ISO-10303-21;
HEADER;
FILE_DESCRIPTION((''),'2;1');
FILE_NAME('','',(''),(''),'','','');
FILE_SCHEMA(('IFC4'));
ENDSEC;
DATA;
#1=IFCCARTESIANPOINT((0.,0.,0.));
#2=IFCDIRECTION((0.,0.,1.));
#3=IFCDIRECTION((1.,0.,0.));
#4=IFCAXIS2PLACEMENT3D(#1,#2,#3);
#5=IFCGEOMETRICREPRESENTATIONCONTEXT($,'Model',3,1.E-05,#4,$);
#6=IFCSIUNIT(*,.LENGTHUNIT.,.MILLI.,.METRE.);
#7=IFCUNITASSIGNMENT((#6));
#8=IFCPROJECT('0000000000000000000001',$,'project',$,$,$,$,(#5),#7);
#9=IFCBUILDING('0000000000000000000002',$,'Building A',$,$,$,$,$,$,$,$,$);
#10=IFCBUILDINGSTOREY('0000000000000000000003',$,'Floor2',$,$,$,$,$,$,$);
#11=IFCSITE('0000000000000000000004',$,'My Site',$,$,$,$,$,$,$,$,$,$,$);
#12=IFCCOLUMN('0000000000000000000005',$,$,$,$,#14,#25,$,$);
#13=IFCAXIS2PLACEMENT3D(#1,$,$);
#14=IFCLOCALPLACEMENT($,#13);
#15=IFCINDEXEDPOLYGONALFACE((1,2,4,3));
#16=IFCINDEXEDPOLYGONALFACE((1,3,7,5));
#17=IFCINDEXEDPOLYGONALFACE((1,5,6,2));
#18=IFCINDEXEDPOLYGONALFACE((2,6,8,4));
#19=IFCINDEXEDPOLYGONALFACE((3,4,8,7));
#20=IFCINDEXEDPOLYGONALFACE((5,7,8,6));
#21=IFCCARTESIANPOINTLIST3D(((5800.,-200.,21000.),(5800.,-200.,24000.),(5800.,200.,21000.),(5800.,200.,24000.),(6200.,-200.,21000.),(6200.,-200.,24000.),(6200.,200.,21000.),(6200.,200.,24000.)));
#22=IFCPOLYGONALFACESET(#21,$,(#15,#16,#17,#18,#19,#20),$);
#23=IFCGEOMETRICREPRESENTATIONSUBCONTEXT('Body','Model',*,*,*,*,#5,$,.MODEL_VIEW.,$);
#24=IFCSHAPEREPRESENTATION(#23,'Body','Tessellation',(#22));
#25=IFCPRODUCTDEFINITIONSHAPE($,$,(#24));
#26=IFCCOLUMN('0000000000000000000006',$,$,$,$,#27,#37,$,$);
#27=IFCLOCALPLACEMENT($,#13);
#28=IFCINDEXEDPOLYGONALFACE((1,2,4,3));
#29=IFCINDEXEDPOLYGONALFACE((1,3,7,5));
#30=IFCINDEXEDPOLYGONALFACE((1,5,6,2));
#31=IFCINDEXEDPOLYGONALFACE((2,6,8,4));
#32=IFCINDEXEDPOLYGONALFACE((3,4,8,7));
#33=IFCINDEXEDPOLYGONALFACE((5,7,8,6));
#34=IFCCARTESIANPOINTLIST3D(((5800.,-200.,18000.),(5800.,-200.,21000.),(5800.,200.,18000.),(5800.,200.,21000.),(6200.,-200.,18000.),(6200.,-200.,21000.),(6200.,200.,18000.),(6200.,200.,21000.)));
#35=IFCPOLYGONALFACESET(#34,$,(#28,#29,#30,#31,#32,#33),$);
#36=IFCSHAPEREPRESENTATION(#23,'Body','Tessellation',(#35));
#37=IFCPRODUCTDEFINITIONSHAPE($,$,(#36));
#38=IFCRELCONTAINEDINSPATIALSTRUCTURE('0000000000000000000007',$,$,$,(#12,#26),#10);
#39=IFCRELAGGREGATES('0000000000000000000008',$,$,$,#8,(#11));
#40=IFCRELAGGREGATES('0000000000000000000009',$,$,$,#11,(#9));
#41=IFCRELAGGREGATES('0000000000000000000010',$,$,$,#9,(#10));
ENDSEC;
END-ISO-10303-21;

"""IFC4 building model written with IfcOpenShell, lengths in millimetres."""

from ifc_helpers import new_model, si_unit, frame, origin_with_axes, place, context, subcontext, project, spatial, line, indexed_curve, outline, extrude, element, save


model = new_model("IFC4")

# Units and contexts
model_context = context("Model", 3, precision=1e-05, world=origin_with_axes())
body_context = subcontext(model_context, "Body", "Model", "MODEL_VIEW")
ifc_project = project(units=[si_unit("LENGTHUNIT", "METRE", prefix="MILLI")], contexts=[model_context])

# Site, building, storey
site = spatial("IfcSite", under=ifc_project, Name="My Site")
building = spatial("IfcBuilding", under=site, Name="Building A")
storey = spatial("IfcBuildingStorey", under=building, Name="Floor2")

# Columns
for number, where, z_axis, x_axis in (
    (1, (6000.0, 0.0, 21000.0), (0.0, 0.0, 1.0), (1.0, 0.0, 0.0)),
    (2, (6000.0, 0.0, 18000.0), (0.0, 0.0, 1.0), (1.0, 0.0, 0.0)),
):
    element("IfcColumn", number, at=place(None, frame(where, z_axis=z_axis, x_axis=x_axis)), inside=storey, context=body_context, shape_type="SweptSolid", body=[
        extrude(outline(indexed_curve([(-200.0, -200.0), (200.0, -200.0), (200.0, 200.0), (-200.0, 200.0)], segments=[line(1, 2, 3, 4, 1)])), origin_with_axes(), (0.0, 0.0, 1.0), 3000.0),
    ])

save(model, "model.ifc")
